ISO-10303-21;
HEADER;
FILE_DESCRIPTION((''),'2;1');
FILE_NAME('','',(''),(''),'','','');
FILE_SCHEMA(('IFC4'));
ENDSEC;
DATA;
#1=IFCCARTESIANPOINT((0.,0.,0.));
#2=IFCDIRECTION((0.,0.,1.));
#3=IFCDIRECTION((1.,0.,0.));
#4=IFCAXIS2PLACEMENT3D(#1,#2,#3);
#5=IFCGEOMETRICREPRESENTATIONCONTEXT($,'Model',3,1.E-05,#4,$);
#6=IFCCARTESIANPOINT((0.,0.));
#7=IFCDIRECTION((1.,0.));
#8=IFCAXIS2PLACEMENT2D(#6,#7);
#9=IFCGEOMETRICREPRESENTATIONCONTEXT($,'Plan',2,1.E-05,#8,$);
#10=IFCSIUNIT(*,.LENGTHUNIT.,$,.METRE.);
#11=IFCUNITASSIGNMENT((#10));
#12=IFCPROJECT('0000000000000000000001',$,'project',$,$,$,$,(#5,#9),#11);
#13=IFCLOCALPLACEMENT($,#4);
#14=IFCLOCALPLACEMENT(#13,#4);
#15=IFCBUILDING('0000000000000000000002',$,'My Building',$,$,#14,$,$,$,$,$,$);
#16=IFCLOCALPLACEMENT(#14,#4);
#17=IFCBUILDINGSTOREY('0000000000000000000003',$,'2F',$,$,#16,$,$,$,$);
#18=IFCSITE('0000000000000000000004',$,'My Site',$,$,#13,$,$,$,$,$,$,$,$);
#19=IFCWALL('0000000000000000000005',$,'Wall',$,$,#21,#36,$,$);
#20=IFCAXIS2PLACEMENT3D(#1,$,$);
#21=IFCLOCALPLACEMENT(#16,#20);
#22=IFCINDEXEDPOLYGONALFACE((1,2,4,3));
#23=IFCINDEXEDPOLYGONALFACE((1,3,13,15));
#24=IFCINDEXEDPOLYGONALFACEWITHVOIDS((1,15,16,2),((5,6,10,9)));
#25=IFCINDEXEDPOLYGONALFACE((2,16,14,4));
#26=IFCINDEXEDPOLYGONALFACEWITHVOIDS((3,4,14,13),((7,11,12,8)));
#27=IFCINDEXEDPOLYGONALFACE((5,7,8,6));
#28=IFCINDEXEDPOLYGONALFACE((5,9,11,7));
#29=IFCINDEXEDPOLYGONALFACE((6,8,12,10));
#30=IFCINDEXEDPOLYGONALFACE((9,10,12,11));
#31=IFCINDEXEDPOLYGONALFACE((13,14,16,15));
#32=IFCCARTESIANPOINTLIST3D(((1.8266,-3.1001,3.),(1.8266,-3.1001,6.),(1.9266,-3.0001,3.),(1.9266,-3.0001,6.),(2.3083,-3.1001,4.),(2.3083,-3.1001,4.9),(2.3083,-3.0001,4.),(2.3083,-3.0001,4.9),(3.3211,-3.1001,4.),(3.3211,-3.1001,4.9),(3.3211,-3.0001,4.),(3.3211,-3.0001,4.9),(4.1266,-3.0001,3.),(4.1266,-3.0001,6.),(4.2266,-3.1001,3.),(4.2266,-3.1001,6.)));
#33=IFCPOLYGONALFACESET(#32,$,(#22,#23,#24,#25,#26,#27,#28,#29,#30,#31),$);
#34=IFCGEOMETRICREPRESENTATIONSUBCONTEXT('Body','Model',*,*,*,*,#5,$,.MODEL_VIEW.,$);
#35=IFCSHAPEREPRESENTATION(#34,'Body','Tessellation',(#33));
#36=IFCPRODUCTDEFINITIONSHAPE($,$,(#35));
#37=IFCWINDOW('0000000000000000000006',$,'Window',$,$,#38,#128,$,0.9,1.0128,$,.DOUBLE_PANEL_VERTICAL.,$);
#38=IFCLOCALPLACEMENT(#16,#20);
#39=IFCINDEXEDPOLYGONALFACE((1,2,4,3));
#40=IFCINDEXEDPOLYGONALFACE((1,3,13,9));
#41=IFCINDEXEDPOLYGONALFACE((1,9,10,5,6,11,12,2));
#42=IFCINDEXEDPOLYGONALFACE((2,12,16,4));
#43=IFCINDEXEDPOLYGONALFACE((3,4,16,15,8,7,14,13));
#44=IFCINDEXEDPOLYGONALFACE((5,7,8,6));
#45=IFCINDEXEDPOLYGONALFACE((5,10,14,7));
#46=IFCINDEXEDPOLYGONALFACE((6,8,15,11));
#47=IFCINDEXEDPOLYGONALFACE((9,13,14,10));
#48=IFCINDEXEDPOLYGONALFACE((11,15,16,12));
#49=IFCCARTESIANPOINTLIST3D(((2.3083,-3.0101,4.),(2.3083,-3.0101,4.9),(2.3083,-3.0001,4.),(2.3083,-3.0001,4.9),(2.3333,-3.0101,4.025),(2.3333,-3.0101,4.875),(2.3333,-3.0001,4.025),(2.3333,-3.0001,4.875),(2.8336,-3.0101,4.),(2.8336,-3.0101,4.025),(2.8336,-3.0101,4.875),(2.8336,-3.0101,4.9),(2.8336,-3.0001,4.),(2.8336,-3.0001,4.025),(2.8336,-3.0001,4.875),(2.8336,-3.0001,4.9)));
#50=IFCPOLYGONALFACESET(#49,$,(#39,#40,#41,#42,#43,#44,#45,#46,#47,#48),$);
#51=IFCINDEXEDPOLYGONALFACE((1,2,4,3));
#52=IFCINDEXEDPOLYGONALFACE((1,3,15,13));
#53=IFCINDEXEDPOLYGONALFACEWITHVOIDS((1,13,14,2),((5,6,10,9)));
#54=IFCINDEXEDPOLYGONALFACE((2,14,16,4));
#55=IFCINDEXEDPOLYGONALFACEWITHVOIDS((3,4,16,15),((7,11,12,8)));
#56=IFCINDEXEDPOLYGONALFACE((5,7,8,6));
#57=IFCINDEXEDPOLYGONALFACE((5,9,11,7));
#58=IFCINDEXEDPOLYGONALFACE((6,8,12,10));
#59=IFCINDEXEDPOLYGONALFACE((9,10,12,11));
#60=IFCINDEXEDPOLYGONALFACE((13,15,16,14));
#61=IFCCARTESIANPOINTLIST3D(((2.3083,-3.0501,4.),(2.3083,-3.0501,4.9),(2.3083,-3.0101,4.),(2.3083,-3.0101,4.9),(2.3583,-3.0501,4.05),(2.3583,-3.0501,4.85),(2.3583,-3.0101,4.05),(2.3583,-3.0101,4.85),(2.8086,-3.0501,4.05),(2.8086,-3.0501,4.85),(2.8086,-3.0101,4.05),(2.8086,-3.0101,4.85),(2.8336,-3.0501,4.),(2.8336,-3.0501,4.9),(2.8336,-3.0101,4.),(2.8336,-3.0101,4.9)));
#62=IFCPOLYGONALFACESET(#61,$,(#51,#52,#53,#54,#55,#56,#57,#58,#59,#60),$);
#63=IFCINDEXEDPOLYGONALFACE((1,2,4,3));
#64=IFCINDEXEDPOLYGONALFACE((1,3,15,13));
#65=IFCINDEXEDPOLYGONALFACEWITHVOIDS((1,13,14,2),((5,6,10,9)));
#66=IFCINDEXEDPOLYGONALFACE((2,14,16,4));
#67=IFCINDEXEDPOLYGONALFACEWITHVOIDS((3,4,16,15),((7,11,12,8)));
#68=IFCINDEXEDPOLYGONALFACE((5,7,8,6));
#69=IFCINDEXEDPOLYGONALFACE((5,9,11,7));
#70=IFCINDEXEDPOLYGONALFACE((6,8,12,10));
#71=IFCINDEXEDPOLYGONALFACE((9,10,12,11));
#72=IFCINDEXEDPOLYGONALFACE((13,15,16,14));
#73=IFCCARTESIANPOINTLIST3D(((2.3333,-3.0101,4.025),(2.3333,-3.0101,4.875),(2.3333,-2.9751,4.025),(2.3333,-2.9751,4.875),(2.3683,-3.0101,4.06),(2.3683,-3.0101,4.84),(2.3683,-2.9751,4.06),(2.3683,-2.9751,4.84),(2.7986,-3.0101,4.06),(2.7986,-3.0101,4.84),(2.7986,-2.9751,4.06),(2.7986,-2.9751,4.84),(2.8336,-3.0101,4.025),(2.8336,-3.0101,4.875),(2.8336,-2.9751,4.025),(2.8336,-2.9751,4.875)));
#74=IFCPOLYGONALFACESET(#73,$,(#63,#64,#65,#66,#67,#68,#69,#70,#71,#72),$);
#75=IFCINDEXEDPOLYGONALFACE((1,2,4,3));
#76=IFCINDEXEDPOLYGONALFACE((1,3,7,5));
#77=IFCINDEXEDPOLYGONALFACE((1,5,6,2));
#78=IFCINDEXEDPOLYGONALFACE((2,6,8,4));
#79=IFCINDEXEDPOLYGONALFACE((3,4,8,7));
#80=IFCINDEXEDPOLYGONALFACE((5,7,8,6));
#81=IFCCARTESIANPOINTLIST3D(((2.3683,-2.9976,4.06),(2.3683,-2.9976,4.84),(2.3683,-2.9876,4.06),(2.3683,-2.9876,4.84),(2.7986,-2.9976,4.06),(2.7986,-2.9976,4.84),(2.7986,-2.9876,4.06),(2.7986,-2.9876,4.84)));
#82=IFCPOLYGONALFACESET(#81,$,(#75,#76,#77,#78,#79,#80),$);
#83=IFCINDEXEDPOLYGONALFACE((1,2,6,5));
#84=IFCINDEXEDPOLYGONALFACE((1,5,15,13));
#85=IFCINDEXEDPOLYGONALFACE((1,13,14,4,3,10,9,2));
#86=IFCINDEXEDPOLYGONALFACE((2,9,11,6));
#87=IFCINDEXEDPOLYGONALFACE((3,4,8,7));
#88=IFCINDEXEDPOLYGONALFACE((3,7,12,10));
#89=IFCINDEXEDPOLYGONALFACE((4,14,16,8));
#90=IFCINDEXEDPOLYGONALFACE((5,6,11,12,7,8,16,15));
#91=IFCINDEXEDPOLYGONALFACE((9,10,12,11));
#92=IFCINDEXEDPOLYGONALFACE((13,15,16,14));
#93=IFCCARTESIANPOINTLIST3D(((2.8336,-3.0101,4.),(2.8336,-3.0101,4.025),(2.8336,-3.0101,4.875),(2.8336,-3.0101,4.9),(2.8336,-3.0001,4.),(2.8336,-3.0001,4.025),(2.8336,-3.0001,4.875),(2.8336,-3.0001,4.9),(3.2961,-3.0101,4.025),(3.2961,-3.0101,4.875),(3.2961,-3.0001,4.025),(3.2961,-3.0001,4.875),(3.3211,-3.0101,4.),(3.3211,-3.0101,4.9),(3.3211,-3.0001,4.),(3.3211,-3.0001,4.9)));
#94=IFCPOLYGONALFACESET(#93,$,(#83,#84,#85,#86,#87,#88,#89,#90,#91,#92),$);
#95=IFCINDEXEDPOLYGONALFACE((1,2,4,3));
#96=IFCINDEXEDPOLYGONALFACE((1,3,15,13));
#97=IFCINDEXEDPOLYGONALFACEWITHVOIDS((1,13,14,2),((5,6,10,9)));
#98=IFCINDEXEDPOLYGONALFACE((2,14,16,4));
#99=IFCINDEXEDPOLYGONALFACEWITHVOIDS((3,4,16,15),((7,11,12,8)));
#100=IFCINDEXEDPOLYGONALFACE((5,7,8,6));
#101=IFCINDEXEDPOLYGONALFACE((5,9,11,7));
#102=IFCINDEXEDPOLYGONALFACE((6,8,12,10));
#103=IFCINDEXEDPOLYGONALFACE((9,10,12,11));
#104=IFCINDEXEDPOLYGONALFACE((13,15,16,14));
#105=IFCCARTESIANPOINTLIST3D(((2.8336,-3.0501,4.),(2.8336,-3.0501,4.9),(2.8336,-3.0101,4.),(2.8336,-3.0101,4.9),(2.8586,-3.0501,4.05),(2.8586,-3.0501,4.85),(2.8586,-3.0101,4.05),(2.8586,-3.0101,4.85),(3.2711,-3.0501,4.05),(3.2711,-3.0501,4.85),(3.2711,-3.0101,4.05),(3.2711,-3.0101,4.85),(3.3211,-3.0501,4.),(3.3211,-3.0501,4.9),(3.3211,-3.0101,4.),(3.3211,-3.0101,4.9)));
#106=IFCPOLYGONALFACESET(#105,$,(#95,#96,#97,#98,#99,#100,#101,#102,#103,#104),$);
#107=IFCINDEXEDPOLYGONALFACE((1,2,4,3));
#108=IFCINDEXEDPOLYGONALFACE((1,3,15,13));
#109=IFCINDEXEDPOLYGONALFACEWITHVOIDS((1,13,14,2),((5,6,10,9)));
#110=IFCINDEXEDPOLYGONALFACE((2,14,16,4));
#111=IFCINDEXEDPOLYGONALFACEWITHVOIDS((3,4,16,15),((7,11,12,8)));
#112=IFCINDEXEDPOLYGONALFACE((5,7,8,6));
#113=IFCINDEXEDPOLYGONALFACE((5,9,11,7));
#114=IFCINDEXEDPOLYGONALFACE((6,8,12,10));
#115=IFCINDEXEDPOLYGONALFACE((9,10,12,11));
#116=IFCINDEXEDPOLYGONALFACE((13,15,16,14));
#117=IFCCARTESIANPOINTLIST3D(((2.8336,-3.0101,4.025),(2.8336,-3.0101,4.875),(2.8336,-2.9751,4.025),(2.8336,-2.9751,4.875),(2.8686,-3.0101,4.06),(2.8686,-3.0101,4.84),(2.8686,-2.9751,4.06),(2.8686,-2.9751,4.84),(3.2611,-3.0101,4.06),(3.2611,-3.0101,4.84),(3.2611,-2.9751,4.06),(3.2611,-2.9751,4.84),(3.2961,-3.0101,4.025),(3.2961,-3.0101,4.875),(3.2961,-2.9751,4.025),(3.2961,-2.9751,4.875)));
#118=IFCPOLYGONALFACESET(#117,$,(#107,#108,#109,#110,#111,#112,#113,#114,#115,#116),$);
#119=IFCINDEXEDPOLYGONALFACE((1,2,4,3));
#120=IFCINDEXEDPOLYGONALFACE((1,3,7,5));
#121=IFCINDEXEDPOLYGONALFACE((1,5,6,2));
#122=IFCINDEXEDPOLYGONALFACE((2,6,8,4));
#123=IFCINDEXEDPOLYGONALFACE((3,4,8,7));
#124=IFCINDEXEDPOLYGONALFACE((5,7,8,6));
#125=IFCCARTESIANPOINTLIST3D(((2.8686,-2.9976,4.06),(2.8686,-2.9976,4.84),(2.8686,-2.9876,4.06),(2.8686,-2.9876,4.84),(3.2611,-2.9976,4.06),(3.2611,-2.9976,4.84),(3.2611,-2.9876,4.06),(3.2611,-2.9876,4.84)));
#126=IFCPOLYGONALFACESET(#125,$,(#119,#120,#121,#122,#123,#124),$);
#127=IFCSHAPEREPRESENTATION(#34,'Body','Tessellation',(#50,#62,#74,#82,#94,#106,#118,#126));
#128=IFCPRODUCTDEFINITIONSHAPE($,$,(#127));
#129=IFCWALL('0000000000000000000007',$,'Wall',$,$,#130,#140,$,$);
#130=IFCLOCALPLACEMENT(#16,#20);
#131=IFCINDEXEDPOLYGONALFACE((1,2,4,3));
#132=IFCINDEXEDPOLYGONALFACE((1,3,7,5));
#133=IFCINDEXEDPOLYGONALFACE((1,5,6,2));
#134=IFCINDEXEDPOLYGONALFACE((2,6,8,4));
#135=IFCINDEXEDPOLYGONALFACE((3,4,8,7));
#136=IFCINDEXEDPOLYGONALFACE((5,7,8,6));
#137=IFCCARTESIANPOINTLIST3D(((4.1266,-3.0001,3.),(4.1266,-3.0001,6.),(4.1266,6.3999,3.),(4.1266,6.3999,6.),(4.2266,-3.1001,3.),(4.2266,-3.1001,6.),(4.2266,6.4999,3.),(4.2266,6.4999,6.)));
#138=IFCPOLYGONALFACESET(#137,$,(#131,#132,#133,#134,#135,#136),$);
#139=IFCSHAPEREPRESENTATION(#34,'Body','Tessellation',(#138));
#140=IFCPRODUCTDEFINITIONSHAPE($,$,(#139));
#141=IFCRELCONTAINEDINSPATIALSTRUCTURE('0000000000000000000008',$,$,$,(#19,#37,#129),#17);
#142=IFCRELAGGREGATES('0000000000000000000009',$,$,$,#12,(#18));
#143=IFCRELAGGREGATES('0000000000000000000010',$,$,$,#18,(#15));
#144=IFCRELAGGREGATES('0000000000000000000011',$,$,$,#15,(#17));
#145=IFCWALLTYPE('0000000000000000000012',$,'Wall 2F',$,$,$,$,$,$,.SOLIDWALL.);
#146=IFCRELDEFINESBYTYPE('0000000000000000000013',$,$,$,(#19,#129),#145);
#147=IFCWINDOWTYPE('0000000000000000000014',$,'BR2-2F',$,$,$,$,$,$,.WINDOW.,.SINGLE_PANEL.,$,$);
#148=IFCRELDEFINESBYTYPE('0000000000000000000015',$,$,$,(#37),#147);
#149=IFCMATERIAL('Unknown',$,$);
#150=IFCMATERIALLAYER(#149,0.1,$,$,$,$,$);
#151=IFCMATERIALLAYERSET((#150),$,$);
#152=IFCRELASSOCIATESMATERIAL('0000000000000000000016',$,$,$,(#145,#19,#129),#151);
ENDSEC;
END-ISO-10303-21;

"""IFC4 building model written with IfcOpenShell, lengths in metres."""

from ifc_helpers import new_model, entity, si_unit, frame, origin_with_axes, origin_2d_with_axis, place, context, subcontext, project, spatial, line, indexed_curve, outline, extrude, shape, source, transform, mapped, material, layer, layer_set, layer_usage, type_object, type_shapes, element, fill, save


model = new_model("IFC4")

# Units and contexts
model_context = context("Model", 3, precision=1e-05, world=origin_with_axes())
plan_context = context("Plan", 2, precision=1e-05, world=origin_2d_with_axis())
body_context_1 = subcontext(model_context, "Body", "Model", "MODEL_VIEW")
body_context_2 = subcontext(plan_context, "Body", "Plan", "PLAN_VIEW")
ifc_project = project(units=[si_unit("LENGTHUNIT", "METRE")], contexts=[model_context, plan_context])

# Site, building, storey
site_placement = place(None, origin_with_axes())
site = spatial("IfcSite", under=ifc_project, at=site_placement, Name="My Site")
building_placement = place(site_placement, origin_with_axes())
building = spatial("IfcBuilding", under=site, at=building_placement, Name="My Building")
storey_placement = place(building_placement, origin_with_axes())
storey = spatial("IfcBuildingStorey", under=building, at=storey_placement, Name="2F")

# Shared definitions
ifc_material = material(Name="Unknown")

# Shared definitions
ifc_layer_1 = layer(ifc_material, 0.1)
ifc_layer_set_1 = layer_set([ifc_layer_1])
wall_type = type_object("IfcWallType", Name="Wall 2F", PredefinedType="SOLIDWALL", material=ifc_layer_set_1)

# Wall, opening, window
ifc_layer_usage_1 = layer_usage(ifc_layer_set_1, "AXIS2", "POSITIVE", 0.0)
wall_1_placement = place(storey_placement, frame((1.8266, -3.1001, 3.0), z_axis=(0.0, 0.0, 1.0), x_axis=(1.0, 0.0, 0.0)))
wall_1 = element("IfcWall", 1, at=wall_1_placement, inside=storey, type_object=wall_type, material=ifc_layer_usage_1, Name="Wall", context=body_context_1, shape_type="SweptSolid", body=[
    extrude(outline(indexed_curve([(0.0, 0.0), (0.1, 0.1), (2.3, 0.1), (2.4, 0.0)], segments=[line(1, 2, 3, 4, 1)])), origin_with_axes(), (0.0, 0.0, 1.0), 3.0),
])
shared_shape_1 = source(origin_with_axes(), body_context_1, "Body", "SweptSolid", [
    extrude(outline(indexed_curve([(0.0, 0.0), (1.0128, 0.0), (1.0128, 0.9), (0.0, 0.9)], segments=[line(1, 2, 3, 4, 1)])), frame((0.0, -0.6, 0.0), z_axis=(0.0, -1.0, 0.0), x_axis=(1.0, 0.0, 0.0)), (0.0, 0.0, -1.0), 1.2),
])
opening_1_placement = place(wall_1_placement, frame((0.4817, 0.0, 1.0), z_axis=(0.0, 0.0, 1.0), x_axis=(1.0, 0.0, 0.0)))
opening_1 = element("IfcOpeningElement", 2, at=opening_1_placement, cuts=wall_1, PredefinedType="OPENING", context=body_context_1, shape_type="MappedRepresentation", body=[
    mapped(shared_shape_1, transform((0.0, 0.0, 0.0), x_axis=(1.0, 0.0, 0.0), y_axis=(0.0, 1.0, 0.0), z_axis=(0.0, 0.0, 1.0), scale=1.0)),
])
window_type_1 = type_object("IfcWindowType", Name="BR2-2F", PartitioningType="SINGLE_PANEL", PredefinedType="WINDOW")
shared_shape_2 = source(origin_with_axes(), body_context_1, "Body", "SweptSolid", [
    extrude(outline(indexed_curve([(0.5254, 0.0), (0.0, 0.0), (0.0, 0.9), (0.5254, 0.9), (0.5254, 0.875), (0.025, 0.875), (0.025, 0.025), (0.5254, 0.025)], segments=[line(1, 2, 3, 4, 5, 6, 7, 8, 1)])), frame((0.0, 0.09, 0.0), z_axis=(0.0, -1.0, 0.0), x_axis=(1.0, 0.0, 0.0)), (0.0, 0.0, -1.0), 0.01),
    extrude(outline(indexed_curve([(0.0, 0.0), (0.5254, 0.0), (0.5254, 0.9), (0.0, 0.9)], segments=[line(1, 2, 3, 4, 1)]), holes=[indexed_curve([(0.05, 0.05), (0.5004, 0.05), (0.5004, 0.85), (0.05, 0.85)], segments=[line(1, 2, 3, 4, 1)])]), frame((0.0, 0.05, 0.0), z_axis=(0.0, -1.0, 0.0), x_axis=(1.0, 0.0, 0.0)), (0.0, 0.0, -1.0), 0.04),
    extrude(outline(indexed_curve([(0.0, 0.0), (0.5004, 0.0), (0.5004, 0.85), (0.0, 0.85)], segments=[line(1, 2, 3, 4, 1)]), holes=[indexed_curve([(0.035, 0.035), (0.4654, 0.035), (0.4654, 0.815), (0.035, 0.815)], segments=[line(1, 2, 3, 4, 1)])]), frame((0.025, 0.09, 0.025), z_axis=(0.0, -1.0, 0.0), x_axis=(1.0, 0.0, 0.0)), (0.0, 0.0, -1.0), 0.035),
    extrude(outline(indexed_curve([(0.035, 0.035), (0.4654, 0.035), (0.4654, 0.815), (0.035, 0.815)], segments=[line(1, 2, 3, 4, 1)])), frame((0.025, 0.1025, 0.025), z_axis=(0.0, -1.0, 0.0), x_axis=(1.0, 0.0, 0.0)), (0.0, 0.0, -1.0), 0.01),
    extrude(outline(indexed_curve([(0.0, 0.9), (0.4875, 0.9), (0.4875, 0.0), (0.0, 0.0), (0.0, 0.025), (0.4625, 0.025), (0.4625, 0.875), (0.0, 0.875)], segments=[line(1, 2, 3, 4, 5, 6, 7, 8, 1)])), frame((0.5254, 0.09, 0.0), z_axis=(0.0, -1.0, 0.0), x_axis=(1.0, 0.0, 0.0)), (0.0, 0.0, -1.0), 0.01),
    extrude(outline(indexed_curve([(0.0, 0.0), (0.4875, 0.0), (0.4875, 0.9), (0.0, 0.9)], segments=[line(1, 2, 3, 4, 1)]), holes=[indexed_curve([(0.025, 0.05), (0.4375, 0.05), (0.4375, 0.85), (0.025, 0.85)], segments=[line(1, 2, 3, 4, 1)])]), frame((0.5254, 0.05, 0.0), z_axis=(0.0, -1.0, 0.0), x_axis=(1.0, 0.0, 0.0)), (0.0, 0.0, -1.0), 0.04),
    extrude(outline(indexed_curve([(0.0, 0.0), (0.4625, 0.0), (0.4625, 0.85), (0.0, 0.85)], segments=[line(1, 2, 3, 4, 1)]), holes=[indexed_curve([(0.035, 0.035), (0.4275, 0.035), (0.4275, 0.815), (0.035, 0.815)], segments=[line(1, 2, 3, 4, 1)])]), frame((0.5254, 0.09, 0.025), z_axis=(0.0, -1.0, 0.0), x_axis=(1.0, 0.0, 0.0)), (0.0, 0.0, -1.0), 0.035),
    extrude(outline(indexed_curve([(0.035, 0.035), (0.4275, 0.035), (0.4275, 0.815), (0.035, 0.815)], segments=[line(1, 2, 3, 4, 1)])), frame((0.5254, 0.1025, 0.025), z_axis=(0.0, -1.0, 0.0), x_axis=(1.0, 0.0, 0.0)), (0.0, 0.0, -1.0), 0.01),
])
shared_shape_3 = source(origin_with_axes(), body_context_2, "Body", "Curve2D", [
    entity("IfcIndexedPolyCurve", entity("IfcCartesianPointList2D", [[0.05, 0.05], [0.5004, 0.05]])),
    entity("IfcIndexedPolyCurve", entity("IfcCartesianPointList2D", [[0.0, 0.1], [0.025, 0.1], [0.025, 0.09], [0.05, 0.09], [0.05, 0.05], [0.0, 0.05]]), [entity("IfcLineIndex", [1, 2, 3, 4, 5, 6, 1])]),
    entity("IfcIndexedPolyCurve", entity("IfcCartesianPointList2D", [[0.5254, 0.1], [0.5254, 0.1], [0.5254, 0.09], [0.5004, 0.09], [0.5004, 0.05], [0.5254, 0.05]])),
    entity("IfcIndexedPolyCurve", entity("IfcCartesianPointList2D", [[0.025, 0.09], [0.06, 0.09], [0.06, 0.125], [0.025, 0.125]]), [entity("IfcLineIndex", [1, 2, 3, 4, 1])]),
    entity("IfcIndexedPolyCurve", entity("IfcCartesianPointList2D", [[0.5254, 0.09], [0.4904, 0.09], [0.4904, 0.125], [0.5254, 0.125]]), [entity("IfcLineIndex", [1, 2, 3, 4, 1])]),
    entity("IfcIndexedPolyCurve", entity("IfcCartesianPointList2D", [[0.06, 0.09], [0.4904, 0.09]])),
    entity("IfcIndexedPolyCurve", entity("IfcCartesianPointList2D", [[0.06, 0.125], [0.4904, 0.125]])),
    entity("IfcIndexedPolyCurve", entity("IfcCartesianPointList2D", [[0.06, 0.1075], [0.4904, 0.1075]])),
    entity("IfcIndexedPolyCurve", entity("IfcCartesianPointList2D", [[0.5504, 0.05], [0.9628, 0.05]])),
    entity("IfcIndexedPolyCurve", entity("IfcCartesianPointList2D", [[0.5254, 0.1], [0.5254, 0.1], [0.5254, 0.09], [0.5504, 0.09], [0.5504, 0.05], [0.5254, 0.05]])),
    entity("IfcIndexedPolyCurve", entity("IfcCartesianPointList2D", [[1.0128, 0.1], [0.9878, 0.1], [0.9878, 0.09], [0.9628, 0.09], [0.9628, 0.05], [1.0128, 0.05]]), [entity("IfcLineIndex", [1, 2, 3, 4, 5, 6, 1])]),
    entity("IfcIndexedPolyCurve", entity("IfcCartesianPointList2D", [[0.5254, 0.09], [0.5604, 0.09], [0.5604, 0.125], [0.5254, 0.125]]), [entity("IfcLineIndex", [1, 2, 3, 4, 1])]),
    entity("IfcIndexedPolyCurve", entity("IfcCartesianPointList2D", [[0.9878, 0.09], [0.9528, 0.09], [0.9528, 0.125], [0.9878, 0.125]]), [entity("IfcLineIndex", [1, 2, 3, 4, 1])]),
    entity("IfcIndexedPolyCurve", entity("IfcCartesianPointList2D", [[0.5604, 0.09], [0.9528, 0.09]])),
    entity("IfcIndexedPolyCurve", entity("IfcCartesianPointList2D", [[0.5604, 0.125], [0.9528, 0.125]])),
    entity("IfcIndexedPolyCurve", entity("IfcCartesianPointList2D", [[0.5604, 0.1075], [0.9528, 0.1075]])),
])
type_shapes(window_type_1, [shared_shape_2, shared_shape_3])
window_1_placement = place(opening_1_placement, frame((0.0, 0.0, 0.0), z_axis=(0.0, 0.0, 1.0), x_axis=(1.0, 0.0, 0.0)))
window_1 = element("IfcWindow", 3, at=window_1_placement, inside=storey, type_object=window_type_1, Name="Window", OverallHeight=0.9, OverallWidth=1.0128, PartitioningType="DOUBLE_PANEL_VERTICAL", shapes=[
    shape(body_context_1, "Body", "MappedRepresentation", [mapped(shared_shape_2, transform((0.0, 0.0, 0.0), x_axis=(1.0, 0.0, 0.0), y_axis=(0.0, 1.0, 0.0), z_axis=(0.0, 0.0, 1.0), scale=1.0))]),
    shape(body_context_2, "Body", "MappedRepresentation", [mapped(shared_shape_3, transform((0.0, 0.0, 0.0), x_axis=(1.0, 0.0, 0.0), y_axis=(0.0, 1.0, 0.0), z_axis=(0.0, 0.0, 1.0), scale=1.0))]),
])
fill(opening_1, window_1)

# Wall
ifc_layer_usage_2 = layer_usage(ifc_layer_set_1, "AXIS2", "POSITIVE", 0.0)
wall_2_placement = place(storey_placement, frame((4.2266, -3.1001, 3.0), z_axis=(0.0, 0.0, 1.0), x_axis=(0.0, 1.0, 0.0)))
element("IfcWall", 4, at=wall_2_placement, inside=storey, type_object=wall_type, material=ifc_layer_usage_2, Name="Wall", context=body_context_1, shape_type="SweptSolid", body=[
    extrude(outline(indexed_curve([(0.0, 0.0), (0.1, 0.1), (9.5, 0.1), (9.6, 0.0)], segments=[line(1, 2, 3, 4, 1)])), origin_with_axes(), (0.0, 0.0, 1.0), 3.0),
])

save(model, "model.ifc")
